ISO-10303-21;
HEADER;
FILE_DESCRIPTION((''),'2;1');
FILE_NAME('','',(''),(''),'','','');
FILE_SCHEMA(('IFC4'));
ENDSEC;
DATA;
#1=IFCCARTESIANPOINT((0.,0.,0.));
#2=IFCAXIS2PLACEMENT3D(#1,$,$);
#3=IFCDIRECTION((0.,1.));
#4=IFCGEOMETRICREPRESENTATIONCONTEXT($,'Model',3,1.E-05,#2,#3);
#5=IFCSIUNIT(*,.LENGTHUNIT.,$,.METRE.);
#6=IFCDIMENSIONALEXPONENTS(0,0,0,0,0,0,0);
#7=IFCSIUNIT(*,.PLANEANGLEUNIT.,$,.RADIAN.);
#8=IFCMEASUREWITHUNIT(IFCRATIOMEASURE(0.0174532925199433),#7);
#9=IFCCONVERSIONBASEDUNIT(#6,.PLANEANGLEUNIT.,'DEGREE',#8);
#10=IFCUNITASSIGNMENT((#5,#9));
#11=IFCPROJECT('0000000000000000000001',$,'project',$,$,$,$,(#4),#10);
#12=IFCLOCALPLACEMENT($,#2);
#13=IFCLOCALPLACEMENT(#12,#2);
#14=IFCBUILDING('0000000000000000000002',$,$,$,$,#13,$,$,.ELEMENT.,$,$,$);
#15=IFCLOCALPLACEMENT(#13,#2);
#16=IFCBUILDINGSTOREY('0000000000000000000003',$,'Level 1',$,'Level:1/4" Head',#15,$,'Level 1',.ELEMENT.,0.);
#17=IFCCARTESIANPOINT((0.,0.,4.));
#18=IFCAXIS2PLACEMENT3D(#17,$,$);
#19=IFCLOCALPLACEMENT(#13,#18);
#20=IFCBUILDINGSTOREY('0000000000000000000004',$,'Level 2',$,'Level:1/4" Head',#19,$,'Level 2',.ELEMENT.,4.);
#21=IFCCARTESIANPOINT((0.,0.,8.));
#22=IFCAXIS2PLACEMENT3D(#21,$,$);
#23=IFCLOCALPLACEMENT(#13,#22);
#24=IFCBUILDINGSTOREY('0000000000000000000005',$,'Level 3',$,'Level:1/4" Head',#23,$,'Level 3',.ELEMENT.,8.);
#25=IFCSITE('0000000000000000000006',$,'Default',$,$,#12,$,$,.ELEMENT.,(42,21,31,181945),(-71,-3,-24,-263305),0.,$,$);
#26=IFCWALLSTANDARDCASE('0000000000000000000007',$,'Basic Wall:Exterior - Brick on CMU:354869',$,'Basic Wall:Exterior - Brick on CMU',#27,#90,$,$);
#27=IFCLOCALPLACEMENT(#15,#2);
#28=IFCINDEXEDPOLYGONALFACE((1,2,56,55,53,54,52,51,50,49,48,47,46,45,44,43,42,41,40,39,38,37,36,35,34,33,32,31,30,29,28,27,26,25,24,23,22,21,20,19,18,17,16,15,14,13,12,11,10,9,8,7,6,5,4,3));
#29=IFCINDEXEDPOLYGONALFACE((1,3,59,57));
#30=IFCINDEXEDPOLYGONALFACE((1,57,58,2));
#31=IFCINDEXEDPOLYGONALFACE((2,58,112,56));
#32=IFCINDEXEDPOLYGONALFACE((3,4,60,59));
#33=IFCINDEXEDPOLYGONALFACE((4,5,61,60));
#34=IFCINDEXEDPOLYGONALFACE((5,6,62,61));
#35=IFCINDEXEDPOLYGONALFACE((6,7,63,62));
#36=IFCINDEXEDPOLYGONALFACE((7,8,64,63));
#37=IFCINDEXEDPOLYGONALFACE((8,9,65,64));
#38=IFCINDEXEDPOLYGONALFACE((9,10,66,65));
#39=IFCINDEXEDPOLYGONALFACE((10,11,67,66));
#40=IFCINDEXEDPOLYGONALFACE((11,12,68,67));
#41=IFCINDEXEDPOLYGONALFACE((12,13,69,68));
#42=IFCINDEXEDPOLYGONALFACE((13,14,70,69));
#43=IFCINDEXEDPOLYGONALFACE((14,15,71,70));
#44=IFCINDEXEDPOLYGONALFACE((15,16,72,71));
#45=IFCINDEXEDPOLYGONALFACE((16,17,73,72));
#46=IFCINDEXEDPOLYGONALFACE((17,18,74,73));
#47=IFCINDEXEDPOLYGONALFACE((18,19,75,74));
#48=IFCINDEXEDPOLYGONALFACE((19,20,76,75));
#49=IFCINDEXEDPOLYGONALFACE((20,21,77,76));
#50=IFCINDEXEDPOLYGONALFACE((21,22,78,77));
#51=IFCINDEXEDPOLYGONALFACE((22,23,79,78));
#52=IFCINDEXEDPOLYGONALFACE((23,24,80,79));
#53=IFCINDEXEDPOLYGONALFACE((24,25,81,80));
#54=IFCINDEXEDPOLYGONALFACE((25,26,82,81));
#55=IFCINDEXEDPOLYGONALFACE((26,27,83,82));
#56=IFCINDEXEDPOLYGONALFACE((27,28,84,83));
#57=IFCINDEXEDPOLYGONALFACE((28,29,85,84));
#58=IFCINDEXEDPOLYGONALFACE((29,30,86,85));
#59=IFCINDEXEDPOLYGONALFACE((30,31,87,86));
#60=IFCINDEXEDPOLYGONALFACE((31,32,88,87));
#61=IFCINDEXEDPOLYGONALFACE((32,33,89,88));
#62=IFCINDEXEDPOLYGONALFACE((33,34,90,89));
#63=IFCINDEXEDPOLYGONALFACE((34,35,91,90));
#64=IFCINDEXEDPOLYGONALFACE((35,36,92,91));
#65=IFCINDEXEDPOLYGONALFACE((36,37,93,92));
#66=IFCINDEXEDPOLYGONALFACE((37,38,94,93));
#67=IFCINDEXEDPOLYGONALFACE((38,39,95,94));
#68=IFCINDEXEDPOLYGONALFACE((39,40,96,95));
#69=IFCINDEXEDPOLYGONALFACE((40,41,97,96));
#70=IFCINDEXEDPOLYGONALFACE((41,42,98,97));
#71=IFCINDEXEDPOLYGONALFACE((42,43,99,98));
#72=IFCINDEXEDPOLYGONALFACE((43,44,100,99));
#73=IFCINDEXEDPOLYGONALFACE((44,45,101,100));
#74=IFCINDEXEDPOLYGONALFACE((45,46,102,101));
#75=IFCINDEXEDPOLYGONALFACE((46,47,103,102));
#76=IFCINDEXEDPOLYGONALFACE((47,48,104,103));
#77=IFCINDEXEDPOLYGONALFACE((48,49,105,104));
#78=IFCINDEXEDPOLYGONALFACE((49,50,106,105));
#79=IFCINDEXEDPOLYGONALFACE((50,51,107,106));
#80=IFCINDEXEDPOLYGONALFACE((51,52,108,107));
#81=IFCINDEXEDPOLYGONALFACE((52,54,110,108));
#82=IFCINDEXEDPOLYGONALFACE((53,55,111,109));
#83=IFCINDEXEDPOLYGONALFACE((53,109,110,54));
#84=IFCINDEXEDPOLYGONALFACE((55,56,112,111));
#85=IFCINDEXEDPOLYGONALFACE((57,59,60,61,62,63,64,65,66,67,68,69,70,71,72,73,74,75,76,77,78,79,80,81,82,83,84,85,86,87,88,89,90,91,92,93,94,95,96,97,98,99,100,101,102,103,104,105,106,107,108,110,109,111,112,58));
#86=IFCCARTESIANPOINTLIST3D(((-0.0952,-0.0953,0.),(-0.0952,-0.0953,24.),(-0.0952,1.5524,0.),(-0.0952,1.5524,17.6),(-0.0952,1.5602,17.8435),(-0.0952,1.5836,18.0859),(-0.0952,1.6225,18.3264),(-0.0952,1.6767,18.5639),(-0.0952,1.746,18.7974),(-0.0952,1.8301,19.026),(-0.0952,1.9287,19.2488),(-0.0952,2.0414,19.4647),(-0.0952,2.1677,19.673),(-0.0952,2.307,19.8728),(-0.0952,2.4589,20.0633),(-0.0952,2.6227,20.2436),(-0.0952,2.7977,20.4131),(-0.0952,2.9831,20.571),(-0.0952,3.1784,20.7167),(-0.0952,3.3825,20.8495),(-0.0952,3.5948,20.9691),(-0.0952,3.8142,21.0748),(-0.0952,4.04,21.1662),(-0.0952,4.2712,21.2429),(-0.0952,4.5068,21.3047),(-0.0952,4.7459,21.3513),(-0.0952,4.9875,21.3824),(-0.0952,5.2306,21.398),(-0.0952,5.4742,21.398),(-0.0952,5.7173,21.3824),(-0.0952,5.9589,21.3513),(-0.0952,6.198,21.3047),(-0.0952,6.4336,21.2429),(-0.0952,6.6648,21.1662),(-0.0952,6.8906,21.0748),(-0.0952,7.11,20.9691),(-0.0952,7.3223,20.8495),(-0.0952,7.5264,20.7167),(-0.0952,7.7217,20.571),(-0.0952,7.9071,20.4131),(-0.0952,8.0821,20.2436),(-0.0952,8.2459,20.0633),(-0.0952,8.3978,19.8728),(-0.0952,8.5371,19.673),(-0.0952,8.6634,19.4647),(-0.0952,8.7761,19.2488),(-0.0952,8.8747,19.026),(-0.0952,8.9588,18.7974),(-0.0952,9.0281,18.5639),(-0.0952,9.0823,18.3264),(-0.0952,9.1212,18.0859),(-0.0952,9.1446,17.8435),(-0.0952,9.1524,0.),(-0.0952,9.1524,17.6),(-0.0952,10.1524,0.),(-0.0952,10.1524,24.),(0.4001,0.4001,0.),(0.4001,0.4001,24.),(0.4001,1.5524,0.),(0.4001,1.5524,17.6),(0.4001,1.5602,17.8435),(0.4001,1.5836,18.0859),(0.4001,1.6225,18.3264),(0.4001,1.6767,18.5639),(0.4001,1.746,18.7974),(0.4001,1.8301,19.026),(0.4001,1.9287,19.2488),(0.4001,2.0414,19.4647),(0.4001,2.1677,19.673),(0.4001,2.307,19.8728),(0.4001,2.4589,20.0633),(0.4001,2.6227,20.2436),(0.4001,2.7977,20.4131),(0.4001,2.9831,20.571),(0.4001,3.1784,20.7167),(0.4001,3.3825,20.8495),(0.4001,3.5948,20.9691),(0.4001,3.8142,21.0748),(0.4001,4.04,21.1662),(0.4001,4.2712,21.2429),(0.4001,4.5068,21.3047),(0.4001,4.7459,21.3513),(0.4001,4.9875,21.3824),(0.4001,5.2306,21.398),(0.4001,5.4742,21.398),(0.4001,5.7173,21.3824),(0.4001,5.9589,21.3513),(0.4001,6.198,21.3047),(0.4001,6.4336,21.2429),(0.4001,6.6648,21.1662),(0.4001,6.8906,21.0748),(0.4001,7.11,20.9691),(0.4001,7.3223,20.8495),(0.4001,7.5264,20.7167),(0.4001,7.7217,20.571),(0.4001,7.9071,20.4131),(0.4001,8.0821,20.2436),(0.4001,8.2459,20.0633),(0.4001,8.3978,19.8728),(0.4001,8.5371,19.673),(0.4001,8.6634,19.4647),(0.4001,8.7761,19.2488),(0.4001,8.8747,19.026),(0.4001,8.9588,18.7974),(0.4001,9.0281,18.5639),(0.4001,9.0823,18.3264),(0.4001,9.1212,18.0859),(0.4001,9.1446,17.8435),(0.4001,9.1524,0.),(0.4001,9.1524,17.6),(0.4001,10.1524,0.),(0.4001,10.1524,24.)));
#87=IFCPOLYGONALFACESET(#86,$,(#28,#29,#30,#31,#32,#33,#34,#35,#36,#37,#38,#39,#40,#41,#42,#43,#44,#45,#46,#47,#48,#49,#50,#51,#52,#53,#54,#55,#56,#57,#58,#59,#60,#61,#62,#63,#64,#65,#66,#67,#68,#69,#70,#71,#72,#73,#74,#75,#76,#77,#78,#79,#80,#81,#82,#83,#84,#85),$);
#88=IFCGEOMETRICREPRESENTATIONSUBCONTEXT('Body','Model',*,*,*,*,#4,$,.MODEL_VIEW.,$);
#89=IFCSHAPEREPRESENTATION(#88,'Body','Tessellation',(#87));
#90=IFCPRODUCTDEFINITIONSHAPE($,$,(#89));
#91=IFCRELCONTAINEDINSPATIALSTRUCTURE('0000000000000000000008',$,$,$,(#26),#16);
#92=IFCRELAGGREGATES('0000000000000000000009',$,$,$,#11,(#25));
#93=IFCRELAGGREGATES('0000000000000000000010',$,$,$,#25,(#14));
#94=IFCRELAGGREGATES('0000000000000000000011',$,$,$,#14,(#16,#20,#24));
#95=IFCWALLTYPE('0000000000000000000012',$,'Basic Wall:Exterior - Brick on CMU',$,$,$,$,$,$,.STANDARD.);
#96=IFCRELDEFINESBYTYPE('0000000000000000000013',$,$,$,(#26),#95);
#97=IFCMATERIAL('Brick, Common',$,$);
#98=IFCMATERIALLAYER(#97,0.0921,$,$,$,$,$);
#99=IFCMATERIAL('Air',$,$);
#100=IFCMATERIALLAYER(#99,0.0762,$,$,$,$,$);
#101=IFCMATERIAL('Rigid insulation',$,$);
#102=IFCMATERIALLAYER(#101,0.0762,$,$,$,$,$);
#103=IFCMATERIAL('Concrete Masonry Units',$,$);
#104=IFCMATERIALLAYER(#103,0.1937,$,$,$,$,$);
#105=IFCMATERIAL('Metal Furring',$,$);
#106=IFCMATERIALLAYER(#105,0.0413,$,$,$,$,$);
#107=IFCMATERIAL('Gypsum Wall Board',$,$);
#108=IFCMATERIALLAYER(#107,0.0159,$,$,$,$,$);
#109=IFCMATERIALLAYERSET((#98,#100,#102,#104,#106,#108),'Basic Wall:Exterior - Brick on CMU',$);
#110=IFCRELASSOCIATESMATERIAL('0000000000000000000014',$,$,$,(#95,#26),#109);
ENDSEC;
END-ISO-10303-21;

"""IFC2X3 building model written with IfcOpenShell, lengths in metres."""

from ifc_helpers import new_model, entity, si_unit, converted_unit, direction, frame, frame_2d, origin, place, context, subcontext, project, spatial, polyline, circle_curve, parameter, trimmed, segment, composite_curve, outline, extrude, material, layer, layer_set, layer_usage, type_object, element, save


model = new_model("IFC2X3")

# Units and contexts
model_context = context("Model", 3, precision=1e-05, world=origin(), true_north=direction((0.0, 1.0)))
body_context = subcontext(model_context, "Body", "Model", "MODEL_VIEW")
ifc_project = project(units=[si_unit("LENGTHUNIT", "METRE"), converted_unit("PLANEANGLEUNIT", "DEGREE", entity("IfcRatioMeasure", 0.0174532925199433), si_unit("PLANEANGLEUNIT", "RADIAN"), dimensions=[0, 0, 0, 0, 0, 0, 0])], contexts=[model_context])

# Site, building, storey
site_placement = place(None, origin())
site = spatial("IfcSite", under=ifc_project, at=site_placement, Name="Default", CompositionType="ELEMENT", RefLatitude=(42, 21, 31, 181945), RefLongitude=(-71, -3, -24, -263305), RefElevation=0.0)
building_placement = place(site_placement, origin())
building = spatial("IfcBuilding", under=site, at=building_placement, CompositionType="ELEMENT")
storey_1_placement = place(building_placement, origin())
storey_1 = spatial("IfcBuildingStorey", under=building, at=storey_1_placement, Name="Level 1", ObjectType="Level:1/4\" Head", LongName="Level 1", CompositionType="ELEMENT", Elevation=0.0)

# Wall, opening
ifc_material_1 = material(Name="Brick, Common")
ifc_layer_1 = layer(ifc_material_1, 0.0921)
ifc_material_2 = material(Name="Air")
ifc_layer_2 = layer(ifc_material_2, 0.0762)
ifc_material_3 = material(Name="Rigid insulation")
ifc_layer_3 = layer(ifc_material_3, 0.0762)
ifc_material_4 = material(Name="Concrete Masonry Units")
ifc_layer_4 = layer(ifc_material_4, 0.1937)
ifc_material_5 = material(Name="Metal Furring")
ifc_layer_5 = layer(ifc_material_5, 0.0413)
ifc_material_6 = material(Name="Gypsum Wall Board")
ifc_layer_6 = layer(ifc_material_6, 0.0159)
ifc_layer_set_1 = layer_set([ifc_layer_1, ifc_layer_2, ifc_layer_3, ifc_layer_4, ifc_layer_5, ifc_layer_6], Name="Basic Wall:Exterior - Brick on CMU")
ifc_layer_usage_1 = layer_usage(ifc_layer_set_1, "AXIS2", "POSITIVE", -0.2477)
wall_type_1 = type_object("IfcWallType", Name="Basic Wall:Exterior - Brick on CMU", PredefinedType="STANDARD", material=ifc_layer_set_1)
wall_1_placement = place(storey_1_placement, frame((0.1524, 10.1524, 0.0), z_axis=(0.0, 0.0, 1.0), x_axis=(0.0, -1.0, 0.0)))
wall_1 = element("IfcWallStandardCase", 1, at=wall_1_placement, inside=storey_1, type_object=wall_type_1, material=ifc_layer_usage_1, Name="Basic Wall:Exterior - Brick on CMU:354869", ObjectType="Basic Wall:Exterior - Brick on CMU", context=body_context, shape_type="SweptSolid", body=[
    extrude(outline(polyline([(0.0, -0.2477), (10.2477, -0.2477), (9.7523, 0.2477), (0.4175, 0.2477), (0.0, 0.2477), (0.0, -0.2477)])), origin(), (0.0, 0.0, 1.0), 24.0),
])
opening_1_placement = place(wall_1_placement, frame((8.6016, -0.4001, 0.0)))
element("IfcOpeningElement", 2, at=opening_1_placement, cuts=wall_1, ObjectType="Opening", context=body_context, shape_type="SweptSolid", body=[
    extrude(outline(composite_curve([segment(polyline([(-3.8, -8.8), (3.8, -8.8)]), True, "CONTINUOUS"), segment(polyline([(3.8, -8.8), (3.8, 8.8)]), True, "CONTINUOUS"), segment(trimmed(circle_curve(frame_2d((0.0, 8.8), x_axis=(-1.0, 0.0)), 3.8), [parameter(180.0)], [parameter(0.0)], True, "PARAMETER"), True, "CONTINUOUS"), segment(polyline([(-3.8, 8.8), (-3.8, -8.8)]), True, "CONTINUOUS")], self_intersect=False)), frame((-3.8016, 0.0, 8.8), z_axis=(0.0, 1.0, 0.0), x_axis=(-1.0, 0.0, 0.0)), (0.0, 0.0, 1.0), 0.8001),
])

# Shared definitions
storey_2_placement = place(building_placement, frame((0.0, 0.0, 4.0)))
storey_2 = spatial("IfcBuildingStorey", under=building, at=storey_2_placement, Name="Level 2", ObjectType="Level:1/4\" Head", LongName="Level 2", CompositionType="ELEMENT", Elevation=4.0)

# Shared definitions
storey_3_placement = place(building_placement, frame((0.0, 0.0, 8.0)))
storey_3 = spatial("IfcBuildingStorey", under=building, at=storey_3_placement, Name="Level 3", ObjectType="Level:1/4\" Head", LongName="Level 3", CompositionType="ELEMENT", Elevation=8.0)

save(model, "model.ifc")
